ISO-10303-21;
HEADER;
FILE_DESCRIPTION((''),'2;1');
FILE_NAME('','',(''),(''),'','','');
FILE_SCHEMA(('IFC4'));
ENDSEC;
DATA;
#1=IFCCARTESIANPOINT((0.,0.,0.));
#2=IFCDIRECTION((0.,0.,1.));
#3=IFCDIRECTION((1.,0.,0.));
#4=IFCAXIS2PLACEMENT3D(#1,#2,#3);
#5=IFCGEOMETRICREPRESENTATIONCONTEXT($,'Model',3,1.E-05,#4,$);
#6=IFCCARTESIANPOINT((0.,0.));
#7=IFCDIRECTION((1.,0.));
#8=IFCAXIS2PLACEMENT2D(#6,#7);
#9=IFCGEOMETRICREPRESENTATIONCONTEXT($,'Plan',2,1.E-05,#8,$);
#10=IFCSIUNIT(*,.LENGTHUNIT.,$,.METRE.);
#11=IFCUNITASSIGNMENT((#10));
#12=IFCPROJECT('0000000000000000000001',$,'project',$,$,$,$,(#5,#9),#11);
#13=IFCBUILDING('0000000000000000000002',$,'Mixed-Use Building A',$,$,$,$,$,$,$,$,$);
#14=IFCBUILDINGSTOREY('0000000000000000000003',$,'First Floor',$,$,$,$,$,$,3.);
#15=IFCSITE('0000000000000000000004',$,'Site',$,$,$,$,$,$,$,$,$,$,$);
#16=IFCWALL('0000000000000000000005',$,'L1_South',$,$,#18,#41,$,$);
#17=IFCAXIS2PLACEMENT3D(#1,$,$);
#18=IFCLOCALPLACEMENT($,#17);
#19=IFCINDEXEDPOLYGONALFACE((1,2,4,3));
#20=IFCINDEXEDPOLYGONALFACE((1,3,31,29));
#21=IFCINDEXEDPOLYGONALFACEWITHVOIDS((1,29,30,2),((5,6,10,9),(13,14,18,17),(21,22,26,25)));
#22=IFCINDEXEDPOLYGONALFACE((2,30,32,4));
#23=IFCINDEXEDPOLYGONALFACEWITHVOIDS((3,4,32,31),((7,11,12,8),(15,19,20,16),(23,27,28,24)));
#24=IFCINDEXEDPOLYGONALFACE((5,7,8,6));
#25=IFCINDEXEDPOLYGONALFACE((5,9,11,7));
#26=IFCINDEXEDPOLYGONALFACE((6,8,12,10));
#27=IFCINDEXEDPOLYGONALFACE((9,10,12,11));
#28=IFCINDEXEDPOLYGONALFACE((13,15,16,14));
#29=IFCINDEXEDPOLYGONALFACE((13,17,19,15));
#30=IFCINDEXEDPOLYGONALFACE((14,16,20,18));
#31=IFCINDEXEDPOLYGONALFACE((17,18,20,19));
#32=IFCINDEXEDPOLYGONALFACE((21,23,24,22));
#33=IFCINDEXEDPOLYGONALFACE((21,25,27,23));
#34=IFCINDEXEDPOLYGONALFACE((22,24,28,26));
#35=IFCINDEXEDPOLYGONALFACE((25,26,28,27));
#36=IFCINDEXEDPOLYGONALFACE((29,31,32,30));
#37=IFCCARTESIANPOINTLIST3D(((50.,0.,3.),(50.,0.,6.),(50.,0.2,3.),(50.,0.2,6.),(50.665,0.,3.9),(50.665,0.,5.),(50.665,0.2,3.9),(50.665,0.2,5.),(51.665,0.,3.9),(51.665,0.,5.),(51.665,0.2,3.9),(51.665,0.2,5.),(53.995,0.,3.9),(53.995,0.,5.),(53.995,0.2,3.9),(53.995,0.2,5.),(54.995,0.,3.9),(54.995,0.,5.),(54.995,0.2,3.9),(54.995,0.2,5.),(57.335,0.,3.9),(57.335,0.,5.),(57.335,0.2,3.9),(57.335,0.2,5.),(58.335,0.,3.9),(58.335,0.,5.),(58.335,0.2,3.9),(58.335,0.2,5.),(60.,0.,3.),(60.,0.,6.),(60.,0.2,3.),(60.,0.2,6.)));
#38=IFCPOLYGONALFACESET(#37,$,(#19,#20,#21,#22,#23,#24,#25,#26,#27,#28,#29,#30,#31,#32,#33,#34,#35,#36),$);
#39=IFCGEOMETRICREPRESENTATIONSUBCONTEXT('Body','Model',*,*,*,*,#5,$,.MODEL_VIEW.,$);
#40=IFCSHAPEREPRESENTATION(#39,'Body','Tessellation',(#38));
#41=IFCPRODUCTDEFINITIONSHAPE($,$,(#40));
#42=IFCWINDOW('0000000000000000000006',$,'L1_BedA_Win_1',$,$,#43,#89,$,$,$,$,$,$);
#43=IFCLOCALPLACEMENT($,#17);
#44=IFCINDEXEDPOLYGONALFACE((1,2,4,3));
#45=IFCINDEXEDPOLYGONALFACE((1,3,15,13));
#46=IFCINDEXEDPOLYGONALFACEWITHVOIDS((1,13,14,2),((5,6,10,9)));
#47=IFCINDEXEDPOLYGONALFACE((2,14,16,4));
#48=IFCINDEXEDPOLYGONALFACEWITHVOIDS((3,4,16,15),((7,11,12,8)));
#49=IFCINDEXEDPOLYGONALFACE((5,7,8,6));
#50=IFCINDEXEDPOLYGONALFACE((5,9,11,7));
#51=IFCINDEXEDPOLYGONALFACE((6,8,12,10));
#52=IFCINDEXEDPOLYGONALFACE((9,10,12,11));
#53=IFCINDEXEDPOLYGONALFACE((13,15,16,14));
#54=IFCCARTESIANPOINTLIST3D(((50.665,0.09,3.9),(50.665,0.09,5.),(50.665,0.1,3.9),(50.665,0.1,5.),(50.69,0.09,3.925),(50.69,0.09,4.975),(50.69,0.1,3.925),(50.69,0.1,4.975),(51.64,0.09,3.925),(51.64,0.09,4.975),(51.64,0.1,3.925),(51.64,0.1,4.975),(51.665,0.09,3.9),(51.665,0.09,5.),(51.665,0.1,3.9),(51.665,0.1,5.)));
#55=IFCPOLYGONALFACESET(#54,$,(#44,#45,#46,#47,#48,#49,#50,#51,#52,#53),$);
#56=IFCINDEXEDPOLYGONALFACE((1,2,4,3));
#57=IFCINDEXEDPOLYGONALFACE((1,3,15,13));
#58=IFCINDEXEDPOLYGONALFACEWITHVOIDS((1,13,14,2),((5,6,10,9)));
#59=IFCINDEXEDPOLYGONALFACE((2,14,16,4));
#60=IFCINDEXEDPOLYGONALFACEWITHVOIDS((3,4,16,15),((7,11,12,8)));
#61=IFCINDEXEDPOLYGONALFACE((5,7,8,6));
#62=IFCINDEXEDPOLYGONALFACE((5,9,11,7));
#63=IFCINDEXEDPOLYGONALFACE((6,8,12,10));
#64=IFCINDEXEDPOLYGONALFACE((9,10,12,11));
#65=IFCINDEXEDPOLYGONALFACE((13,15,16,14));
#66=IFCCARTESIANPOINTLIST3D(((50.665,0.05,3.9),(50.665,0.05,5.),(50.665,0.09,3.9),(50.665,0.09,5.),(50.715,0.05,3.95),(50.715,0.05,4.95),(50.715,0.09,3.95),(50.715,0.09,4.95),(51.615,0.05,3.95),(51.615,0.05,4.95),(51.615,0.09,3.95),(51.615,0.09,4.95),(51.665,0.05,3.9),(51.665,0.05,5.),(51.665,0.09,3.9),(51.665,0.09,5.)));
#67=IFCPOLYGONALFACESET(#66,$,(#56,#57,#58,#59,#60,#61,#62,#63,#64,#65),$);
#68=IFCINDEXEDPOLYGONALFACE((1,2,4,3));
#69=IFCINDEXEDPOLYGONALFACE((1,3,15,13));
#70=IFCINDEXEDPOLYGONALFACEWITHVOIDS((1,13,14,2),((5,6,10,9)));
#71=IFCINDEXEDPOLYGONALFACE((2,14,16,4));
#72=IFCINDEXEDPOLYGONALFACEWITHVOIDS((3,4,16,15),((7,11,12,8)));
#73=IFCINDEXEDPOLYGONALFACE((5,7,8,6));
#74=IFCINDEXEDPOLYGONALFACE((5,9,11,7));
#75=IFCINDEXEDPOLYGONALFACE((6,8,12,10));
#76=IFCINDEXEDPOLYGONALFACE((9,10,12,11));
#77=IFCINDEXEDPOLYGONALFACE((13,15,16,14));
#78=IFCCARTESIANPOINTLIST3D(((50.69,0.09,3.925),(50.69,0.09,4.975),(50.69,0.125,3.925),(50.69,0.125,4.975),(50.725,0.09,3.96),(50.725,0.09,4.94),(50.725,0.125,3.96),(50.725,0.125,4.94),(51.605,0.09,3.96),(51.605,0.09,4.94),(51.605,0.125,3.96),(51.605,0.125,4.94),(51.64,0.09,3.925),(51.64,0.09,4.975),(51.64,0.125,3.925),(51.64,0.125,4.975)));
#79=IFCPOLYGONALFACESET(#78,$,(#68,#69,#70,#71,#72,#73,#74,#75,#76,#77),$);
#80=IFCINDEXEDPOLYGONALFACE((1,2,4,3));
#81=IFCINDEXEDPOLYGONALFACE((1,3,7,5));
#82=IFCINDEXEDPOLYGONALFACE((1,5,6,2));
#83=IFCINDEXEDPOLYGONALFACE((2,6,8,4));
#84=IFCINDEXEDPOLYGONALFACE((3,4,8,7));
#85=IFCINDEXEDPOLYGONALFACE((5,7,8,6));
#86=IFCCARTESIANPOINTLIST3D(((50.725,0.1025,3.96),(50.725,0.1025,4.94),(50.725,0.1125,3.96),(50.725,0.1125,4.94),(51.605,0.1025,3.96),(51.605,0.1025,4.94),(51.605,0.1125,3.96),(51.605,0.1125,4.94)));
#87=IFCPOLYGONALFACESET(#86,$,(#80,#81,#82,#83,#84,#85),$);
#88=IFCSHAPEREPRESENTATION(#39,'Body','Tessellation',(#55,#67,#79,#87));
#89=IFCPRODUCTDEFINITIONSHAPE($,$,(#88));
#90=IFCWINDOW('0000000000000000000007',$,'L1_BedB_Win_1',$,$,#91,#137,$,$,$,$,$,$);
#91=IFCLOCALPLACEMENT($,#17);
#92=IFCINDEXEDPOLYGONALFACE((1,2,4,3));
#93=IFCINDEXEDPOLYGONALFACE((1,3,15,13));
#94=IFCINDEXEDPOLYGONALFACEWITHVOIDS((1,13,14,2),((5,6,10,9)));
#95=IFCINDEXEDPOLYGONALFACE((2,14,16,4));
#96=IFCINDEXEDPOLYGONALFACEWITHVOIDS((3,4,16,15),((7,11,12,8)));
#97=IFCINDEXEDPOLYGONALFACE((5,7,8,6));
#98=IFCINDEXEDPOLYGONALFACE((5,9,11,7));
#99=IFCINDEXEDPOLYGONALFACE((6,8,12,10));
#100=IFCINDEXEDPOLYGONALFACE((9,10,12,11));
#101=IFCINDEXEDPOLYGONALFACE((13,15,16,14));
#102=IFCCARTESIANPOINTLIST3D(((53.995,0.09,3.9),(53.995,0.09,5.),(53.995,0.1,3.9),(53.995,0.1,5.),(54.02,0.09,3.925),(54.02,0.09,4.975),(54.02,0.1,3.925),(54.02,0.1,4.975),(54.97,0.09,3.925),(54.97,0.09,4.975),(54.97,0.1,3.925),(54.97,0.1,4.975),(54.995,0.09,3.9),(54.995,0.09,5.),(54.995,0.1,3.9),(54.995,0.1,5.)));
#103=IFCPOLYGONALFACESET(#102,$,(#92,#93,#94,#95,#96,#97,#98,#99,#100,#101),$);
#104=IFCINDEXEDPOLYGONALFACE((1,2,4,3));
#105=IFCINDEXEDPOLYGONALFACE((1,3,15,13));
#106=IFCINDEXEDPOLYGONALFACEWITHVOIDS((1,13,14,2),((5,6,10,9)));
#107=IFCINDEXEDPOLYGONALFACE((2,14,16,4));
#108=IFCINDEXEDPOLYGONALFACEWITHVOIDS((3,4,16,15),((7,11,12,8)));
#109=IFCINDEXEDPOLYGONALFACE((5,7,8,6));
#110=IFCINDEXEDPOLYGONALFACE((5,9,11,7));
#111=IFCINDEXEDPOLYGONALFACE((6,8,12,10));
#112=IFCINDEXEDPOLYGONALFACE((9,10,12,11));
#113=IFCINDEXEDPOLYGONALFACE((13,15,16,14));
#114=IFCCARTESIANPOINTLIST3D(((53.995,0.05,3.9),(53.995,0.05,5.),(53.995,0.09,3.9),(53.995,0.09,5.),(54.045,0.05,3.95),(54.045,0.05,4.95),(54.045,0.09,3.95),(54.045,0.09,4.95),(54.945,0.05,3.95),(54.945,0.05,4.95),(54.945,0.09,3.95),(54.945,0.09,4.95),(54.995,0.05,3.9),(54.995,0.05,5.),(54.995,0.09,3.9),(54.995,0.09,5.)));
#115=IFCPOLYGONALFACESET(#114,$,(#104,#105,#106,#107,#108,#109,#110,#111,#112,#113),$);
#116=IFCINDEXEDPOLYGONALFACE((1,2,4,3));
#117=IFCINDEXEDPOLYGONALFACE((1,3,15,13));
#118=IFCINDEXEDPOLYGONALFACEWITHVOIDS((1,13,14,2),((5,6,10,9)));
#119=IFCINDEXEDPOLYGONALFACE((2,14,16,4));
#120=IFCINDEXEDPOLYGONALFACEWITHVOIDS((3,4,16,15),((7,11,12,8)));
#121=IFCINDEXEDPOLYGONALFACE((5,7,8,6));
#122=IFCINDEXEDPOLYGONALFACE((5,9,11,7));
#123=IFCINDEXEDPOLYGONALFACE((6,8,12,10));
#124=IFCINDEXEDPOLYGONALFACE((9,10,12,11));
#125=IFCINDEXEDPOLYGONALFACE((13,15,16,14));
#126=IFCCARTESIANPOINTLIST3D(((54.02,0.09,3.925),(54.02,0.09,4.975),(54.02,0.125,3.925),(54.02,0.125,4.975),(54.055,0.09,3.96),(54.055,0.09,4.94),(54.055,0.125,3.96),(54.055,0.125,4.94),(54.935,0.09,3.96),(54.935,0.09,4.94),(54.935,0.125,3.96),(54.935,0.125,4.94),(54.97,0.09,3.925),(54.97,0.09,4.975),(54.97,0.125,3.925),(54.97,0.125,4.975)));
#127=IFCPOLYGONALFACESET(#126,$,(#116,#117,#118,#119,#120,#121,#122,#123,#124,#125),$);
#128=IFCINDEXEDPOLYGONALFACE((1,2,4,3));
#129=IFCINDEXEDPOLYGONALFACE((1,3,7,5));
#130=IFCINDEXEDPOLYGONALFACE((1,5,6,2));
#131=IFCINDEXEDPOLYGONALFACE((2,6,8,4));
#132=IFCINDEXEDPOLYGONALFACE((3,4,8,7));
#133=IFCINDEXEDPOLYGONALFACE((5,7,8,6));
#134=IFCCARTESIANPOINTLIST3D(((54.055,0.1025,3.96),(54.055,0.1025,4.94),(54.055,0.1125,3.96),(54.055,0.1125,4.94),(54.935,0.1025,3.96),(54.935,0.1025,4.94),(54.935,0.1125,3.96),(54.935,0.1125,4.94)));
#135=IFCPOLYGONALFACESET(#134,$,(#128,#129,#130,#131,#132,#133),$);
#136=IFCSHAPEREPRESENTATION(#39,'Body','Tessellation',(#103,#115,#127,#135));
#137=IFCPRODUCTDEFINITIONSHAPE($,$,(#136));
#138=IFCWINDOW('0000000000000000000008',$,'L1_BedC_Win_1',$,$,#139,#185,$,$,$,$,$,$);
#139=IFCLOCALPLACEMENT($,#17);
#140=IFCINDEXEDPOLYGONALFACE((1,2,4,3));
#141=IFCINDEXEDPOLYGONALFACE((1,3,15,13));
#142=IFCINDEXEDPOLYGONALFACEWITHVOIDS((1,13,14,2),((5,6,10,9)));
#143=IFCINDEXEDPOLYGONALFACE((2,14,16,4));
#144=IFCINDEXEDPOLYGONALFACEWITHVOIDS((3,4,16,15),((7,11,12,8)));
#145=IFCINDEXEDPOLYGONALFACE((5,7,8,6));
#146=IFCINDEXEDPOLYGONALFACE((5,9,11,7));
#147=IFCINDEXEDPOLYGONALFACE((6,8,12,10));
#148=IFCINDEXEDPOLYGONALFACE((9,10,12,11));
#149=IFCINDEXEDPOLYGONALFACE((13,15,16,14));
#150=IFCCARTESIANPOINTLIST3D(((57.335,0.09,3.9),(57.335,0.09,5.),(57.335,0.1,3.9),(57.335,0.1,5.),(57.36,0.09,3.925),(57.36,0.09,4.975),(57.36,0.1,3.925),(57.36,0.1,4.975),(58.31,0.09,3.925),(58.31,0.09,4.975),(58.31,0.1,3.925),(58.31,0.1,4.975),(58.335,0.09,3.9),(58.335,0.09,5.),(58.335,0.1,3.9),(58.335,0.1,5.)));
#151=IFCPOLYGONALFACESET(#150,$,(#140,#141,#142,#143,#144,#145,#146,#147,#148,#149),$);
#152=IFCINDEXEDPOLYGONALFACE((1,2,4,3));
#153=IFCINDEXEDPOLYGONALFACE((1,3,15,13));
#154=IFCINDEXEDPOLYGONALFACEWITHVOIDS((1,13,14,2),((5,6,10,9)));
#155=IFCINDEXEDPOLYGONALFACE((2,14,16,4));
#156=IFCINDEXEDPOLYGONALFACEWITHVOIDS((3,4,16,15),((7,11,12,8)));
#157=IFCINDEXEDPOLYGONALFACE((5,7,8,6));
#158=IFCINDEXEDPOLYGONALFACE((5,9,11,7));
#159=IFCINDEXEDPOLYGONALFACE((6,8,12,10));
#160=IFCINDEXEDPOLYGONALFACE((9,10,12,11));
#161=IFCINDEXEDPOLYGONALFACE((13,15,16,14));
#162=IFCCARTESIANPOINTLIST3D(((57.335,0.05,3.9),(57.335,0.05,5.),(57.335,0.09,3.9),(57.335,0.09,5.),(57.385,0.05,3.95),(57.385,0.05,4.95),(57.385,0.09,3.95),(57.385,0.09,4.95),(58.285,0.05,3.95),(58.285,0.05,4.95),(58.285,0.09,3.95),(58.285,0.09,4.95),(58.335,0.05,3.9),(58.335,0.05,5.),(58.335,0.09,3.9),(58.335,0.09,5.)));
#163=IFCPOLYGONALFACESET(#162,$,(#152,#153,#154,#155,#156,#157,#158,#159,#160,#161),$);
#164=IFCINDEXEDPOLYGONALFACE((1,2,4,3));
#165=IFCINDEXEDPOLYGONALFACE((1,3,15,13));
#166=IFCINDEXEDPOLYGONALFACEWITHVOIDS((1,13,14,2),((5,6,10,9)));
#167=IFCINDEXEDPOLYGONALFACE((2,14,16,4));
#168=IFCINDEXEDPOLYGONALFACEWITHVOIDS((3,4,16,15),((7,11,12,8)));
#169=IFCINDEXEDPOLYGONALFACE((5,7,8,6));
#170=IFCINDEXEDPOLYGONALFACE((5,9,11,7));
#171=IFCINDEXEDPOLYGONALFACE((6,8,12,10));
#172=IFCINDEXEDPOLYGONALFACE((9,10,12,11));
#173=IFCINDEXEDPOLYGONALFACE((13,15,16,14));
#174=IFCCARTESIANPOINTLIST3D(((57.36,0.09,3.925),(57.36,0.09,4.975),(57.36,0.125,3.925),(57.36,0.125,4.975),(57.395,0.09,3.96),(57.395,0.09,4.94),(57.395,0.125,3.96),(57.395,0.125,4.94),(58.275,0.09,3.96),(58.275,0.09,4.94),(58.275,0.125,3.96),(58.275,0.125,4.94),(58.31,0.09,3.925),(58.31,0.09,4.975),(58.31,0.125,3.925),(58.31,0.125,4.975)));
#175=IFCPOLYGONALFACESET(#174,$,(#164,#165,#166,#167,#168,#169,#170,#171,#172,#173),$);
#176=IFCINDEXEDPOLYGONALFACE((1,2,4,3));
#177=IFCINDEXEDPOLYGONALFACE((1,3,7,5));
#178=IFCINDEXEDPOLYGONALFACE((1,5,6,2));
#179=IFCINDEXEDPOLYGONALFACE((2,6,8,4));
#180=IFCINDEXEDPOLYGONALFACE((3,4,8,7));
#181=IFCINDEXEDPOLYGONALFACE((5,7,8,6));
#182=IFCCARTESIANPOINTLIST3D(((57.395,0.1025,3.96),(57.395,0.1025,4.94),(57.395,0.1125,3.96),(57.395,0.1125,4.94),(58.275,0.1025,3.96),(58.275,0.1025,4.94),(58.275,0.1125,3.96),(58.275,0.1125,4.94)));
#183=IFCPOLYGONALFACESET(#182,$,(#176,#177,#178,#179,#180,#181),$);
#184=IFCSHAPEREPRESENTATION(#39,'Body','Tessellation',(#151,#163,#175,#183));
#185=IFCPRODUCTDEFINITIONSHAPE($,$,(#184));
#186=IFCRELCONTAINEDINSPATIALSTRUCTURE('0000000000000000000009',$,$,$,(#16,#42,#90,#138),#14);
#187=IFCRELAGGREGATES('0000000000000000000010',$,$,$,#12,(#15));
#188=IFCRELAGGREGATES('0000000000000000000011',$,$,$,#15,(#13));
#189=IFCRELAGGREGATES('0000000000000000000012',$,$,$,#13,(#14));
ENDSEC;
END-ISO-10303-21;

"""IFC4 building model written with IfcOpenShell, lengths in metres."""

from ifc_helpers import new_model, si_unit, frame, origin_with_axes, origin_2d_with_axis, place, context, subcontext, project, spatial, line, indexed_curve, outline, extrude, element, fill, save


model = new_model("IFC4")

# Units and contexts
model_context = context("Model", 3, precision=1e-05, world=origin_with_axes())
plan_context = context("Plan", 2, precision=1e-05, world=origin_2d_with_axis())
body_context = subcontext(model_context, "Body", "Model", "MODEL_VIEW")
ifc_project = project(units=[si_unit("LENGTHUNIT", "METRE")], contexts=[model_context, plan_context])

# Site, building, storey
site = spatial("IfcSite", under=ifc_project, Name="Site")
building = spatial("IfcBuilding", under=site, Name="Mixed-Use Building A")
storey = spatial("IfcBuildingStorey", under=building, Name="First Floor", Elevation=3.0)

# Wall, openings, windows
wall_1_placement = place(None, frame((50.0, 0.0, 3.0), z_axis=(0.0, 0.0, 1.0), x_axis=(1.0, 0.0, 0.0)))
wall_1 = element("IfcWall", 1, at=wall_1_placement, inside=storey, Name="L1_South", context=body_context, shape_type="SweptSolid", body=[
    extrude(outline(indexed_curve([(0.0, 0.0), (0.0, 0.2), (10.0, 0.2), (10.0, 0.0), (0.0, 0.0)], self_intersect=False)), origin_with_axes(), (0.0, 0.0, 1.0), 3.0),
])
opening_1_placement = place(wall_1_placement, frame((0.665, 0.0, 0.9), z_axis=(0.0, 0.0, 1.0), x_axis=(1.0, 0.0, 0.0)))
opening_1 = element("IfcOpeningElement", 2, at=opening_1_placement, cuts=wall_1, context=body_context, shape_type="SweptSolid", body=[
    extrude(outline(indexed_curve([(0.0, 0.0), (0.0, 0.3), (1.0, 0.3), (1.0, 0.0), (0.0, 0.0)], self_intersect=False)), origin_with_axes(), (0.0, 0.0, 1.0), 1.1),
])
opening_2_placement = place(wall_1_placement, frame((3.995, 0.0, 0.9), z_axis=(0.0, 0.0, 1.0), x_axis=(1.0, 0.0, 0.0)))
opening_2 = element("IfcOpeningElement", 3, at=opening_2_placement, cuts=wall_1, context=body_context, shape_type="SweptSolid", body=[
    extrude(outline(indexed_curve([(0.0, 0.0), (0.0, 0.3), (1.0, 0.3), (1.0, 0.0), (0.0, 0.0)], self_intersect=False)), origin_with_axes(), (0.0, 0.0, 1.0), 1.1),
])
opening_3_placement = place(wall_1_placement, frame((7.335, 0.0, 0.9), z_axis=(0.0, 0.0, 1.0), x_axis=(1.0, 0.0, 0.0)))
opening_3 = element("IfcOpeningElement", 4, at=opening_3_placement, cuts=wall_1, context=body_context, shape_type="SweptSolid", body=[
    extrude(outline(indexed_curve([(0.0, 0.0), (0.0, 0.3), (1.0, 0.3), (1.0, 0.0), (0.0, 0.0)], self_intersect=False)), origin_with_axes(), (0.0, 0.0, 1.0), 1.1),
])
window_1_placement = place(None, frame((50.665, 0.0, 3.9), z_axis=(0.0, 0.0, 1.0), x_axis=(1.0, 0.0, 0.0)))
window_1 = element("IfcWindow", 5, at=window_1_placement, inside=storey, Name="L1_BedA_Win_1", context=body_context, shape_type="SweptSolid", body=[
    extrude(outline(indexed_curve([(0.0, 0.0), (1.0, 0.0), (1.0, 1.1), (0.0, 1.1)], segments=[line(1, 2, 3, 4, 1)]), holes=[indexed_curve([(0.025, 0.025), (0.975, 0.025), (0.975, 1.075), (0.025, 1.075)], segments=[line(1, 2, 3, 4, 1)])]), frame((0.0, 0.09, 0.0), z_axis=(0.0, -1.0, 0.0), x_axis=(1.0, 0.0, 0.0)), (0.0, 0.0, -1.0), 0.01),
    extrude(outline(indexed_curve([(0.0, 0.0), (1.0, 0.0), (1.0, 1.1), (0.0, 1.1)], segments=[line(1, 2, 3, 4, 1)]), holes=[indexed_curve([(0.05, 0.05), (0.95, 0.05), (0.95, 1.05), (0.05, 1.05)], segments=[line(1, 2, 3, 4, 1)])]), frame((0.0, 0.05, 0.0), z_axis=(0.0, -1.0, 0.0), x_axis=(1.0, 0.0, 0.0)), (0.0, 0.0, -1.0), 0.04),
    extrude(outline(indexed_curve([(0.0, 0.0), (0.95, 0.0), (0.95, 1.05), (0.0, 1.05)], segments=[line(1, 2, 3, 4, 1)]), holes=[indexed_curve([(0.035, 0.035), (0.915, 0.035), (0.915, 1.015), (0.035, 1.015)], segments=[line(1, 2, 3, 4, 1)])]), frame((0.025, 0.09, 0.025), z_axis=(0.0, -1.0, 0.0), x_axis=(1.0, 0.0, 0.0)), (0.0, 0.0, -1.0), 0.035),
    extrude(outline(indexed_curve([(0.035, 0.035), (0.915, 0.035), (0.915, 1.015), (0.035, 1.015)], segments=[line(1, 2, 3, 4, 1)])), frame((0.025, 0.1025, 0.025), z_axis=(0.0, -1.0, 0.0), x_axis=(1.0, 0.0, 0.0)), (0.0, 0.0, -1.0), 0.01),
])
fill(opening_1, window_1)
window_2_placement = place(None, frame((53.995, 0.0, 3.9), z_axis=(0.0, 0.0, 1.0), x_axis=(1.0, 0.0, 0.0)))
window_2 = element("IfcWindow", 6, at=window_2_placement, inside=storey, Name="L1_BedB_Win_1", context=body_context, shape_type="SweptSolid", body=[
    extrude(outline(indexed_curve([(0.0, 0.0), (1.0, 0.0), (1.0, 1.1), (0.0, 1.1)], segments=[line(1, 2, 3, 4, 1)]), holes=[indexed_curve([(0.025, 0.025), (0.975, 0.025), (0.975, 1.075), (0.025, 1.075)], segments=[line(1, 2, 3, 4, 1)])]), frame((0.0, 0.09, 0.0), z_axis=(0.0, -1.0, 0.0), x_axis=(1.0, 0.0, 0.0)), (0.0, 0.0, -1.0), 0.01),
    extrude(outline(indexed_curve([(0.0, 0.0), (1.0, 0.0), (1.0, 1.1), (0.0, 1.1)], segments=[line(1, 2, 3, 4, 1)]), holes=[indexed_curve([(0.05, 0.05), (0.95, 0.05), (0.95, 1.05), (0.05, 1.05)], segments=[line(1, 2, 3, 4, 1)])]), frame((0.0, 0.05, 0.0), z_axis=(0.0, -1.0, 0.0), x_axis=(1.0, 0.0, 0.0)), (0.0, 0.0, -1.0), 0.04),
    extrude(outline(indexed_curve([(0.0, 0.0), (0.95, 0.0), (0.95, 1.05), (0.0, 1.05)], segments=[line(1, 2, 3, 4, 1)]), holes=[indexed_curve([(0.035, 0.035), (0.915, 0.035), (0.915, 1.015), (0.035, 1.015)], segments=[line(1, 2, 3, 4, 1)])]), frame((0.025, 0.09, 0.025), z_axis=(0.0, -1.0, 0.0), x_axis=(1.0, 0.0, 0.0)), (0.0, 0.0, -1.0), 0.035),
    extrude(outline(indexed_curve([(0.035, 0.035), (0.915, 0.035), (0.915, 1.015), (0.035, 1.015)], segments=[line(1, 2, 3, 4, 1)])), frame((0.025, 0.1025, 0.025), z_axis=(0.0, -1.0, 0.0), x_axis=(1.0, 0.0, 0.0)), (0.0, 0.0, -1.0), 0.01),
])
fill(opening_2, window_2)
window_3_placement = place(None, frame((57.335, 0.0, 3.9), z_axis=(0.0, 0.0, 1.0), x_axis=(1.0, 0.0, 0.0)))
window_3 = element("IfcWindow", 7, at=window_3_placement, inside=storey, Name="L1_BedC_Win_1", context=body_context, shape_type="SweptSolid", body=[
    extrude(outline(indexed_curve([(0.0, 0.0), (1.0, 0.0), (1.0, 1.1), (0.0, 1.1)], segments=[line(1, 2, 3, 4, 1)]), holes=[indexed_curve([(0.025, 0.025), (0.975, 0.025), (0.975, 1.075), (0.025, 1.075)], segments=[line(1, 2, 3, 4, 1)])]), frame((0.0, 0.09, 0.0), z_axis=(0.0, -1.0, 0.0), x_axis=(1.0, 0.0, 0.0)), (0.0, 0.0, -1.0), 0.01),
    extrude(outline(indexed_curve([(0.0, 0.0), (1.0, 0.0), (1.0, 1.1), (0.0, 1.1)], segments=[line(1, 2, 3, 4, 1)]), holes=[indexed_curve([(0.05, 0.05), (0.95, 0.05), (0.95, 1.05), (0.05, 1.05)], segments=[line(1, 2, 3, 4, 1)])]), frame((0.0, 0.05, 0.0), z_axis=(0.0, -1.0, 0.0), x_axis=(1.0, 0.0, 0.0)), (0.0, 0.0, -1.0), 0.04),
    extrude(outline(indexed_curve([(0.0, 0.0), (0.95, 0.0), (0.95, 1.05), (0.0, 1.05)], segments=[line(1, 2, 3, 4, 1)]), holes=[indexed_curve([(0.035, 0.035), (0.915, 0.035), (0.915, 1.015), (0.035, 1.015)], segments=[line(1, 2, 3, 4, 1)])]), frame((0.025, 0.09, 0.025), z_axis=(0.0, -1.0, 0.0), x_axis=(1.0, 0.0, 0.0)), (0.0, 0.0, -1.0), 0.035),
    extrude(outline(indexed_curve([(0.035, 0.035), (0.915, 0.035), (0.915, 1.015), (0.035, 1.015)], segments=[line(1, 2, 3, 4, 1)])), frame((0.025, 0.1025, 0.025), z_axis=(0.0, -1.0, 0.0), x_axis=(1.0, 0.0, 0.0)), (0.0, 0.0, -1.0), 0.01),
])
fill(opening_3, window_3)

save(model, "model.ifc")
